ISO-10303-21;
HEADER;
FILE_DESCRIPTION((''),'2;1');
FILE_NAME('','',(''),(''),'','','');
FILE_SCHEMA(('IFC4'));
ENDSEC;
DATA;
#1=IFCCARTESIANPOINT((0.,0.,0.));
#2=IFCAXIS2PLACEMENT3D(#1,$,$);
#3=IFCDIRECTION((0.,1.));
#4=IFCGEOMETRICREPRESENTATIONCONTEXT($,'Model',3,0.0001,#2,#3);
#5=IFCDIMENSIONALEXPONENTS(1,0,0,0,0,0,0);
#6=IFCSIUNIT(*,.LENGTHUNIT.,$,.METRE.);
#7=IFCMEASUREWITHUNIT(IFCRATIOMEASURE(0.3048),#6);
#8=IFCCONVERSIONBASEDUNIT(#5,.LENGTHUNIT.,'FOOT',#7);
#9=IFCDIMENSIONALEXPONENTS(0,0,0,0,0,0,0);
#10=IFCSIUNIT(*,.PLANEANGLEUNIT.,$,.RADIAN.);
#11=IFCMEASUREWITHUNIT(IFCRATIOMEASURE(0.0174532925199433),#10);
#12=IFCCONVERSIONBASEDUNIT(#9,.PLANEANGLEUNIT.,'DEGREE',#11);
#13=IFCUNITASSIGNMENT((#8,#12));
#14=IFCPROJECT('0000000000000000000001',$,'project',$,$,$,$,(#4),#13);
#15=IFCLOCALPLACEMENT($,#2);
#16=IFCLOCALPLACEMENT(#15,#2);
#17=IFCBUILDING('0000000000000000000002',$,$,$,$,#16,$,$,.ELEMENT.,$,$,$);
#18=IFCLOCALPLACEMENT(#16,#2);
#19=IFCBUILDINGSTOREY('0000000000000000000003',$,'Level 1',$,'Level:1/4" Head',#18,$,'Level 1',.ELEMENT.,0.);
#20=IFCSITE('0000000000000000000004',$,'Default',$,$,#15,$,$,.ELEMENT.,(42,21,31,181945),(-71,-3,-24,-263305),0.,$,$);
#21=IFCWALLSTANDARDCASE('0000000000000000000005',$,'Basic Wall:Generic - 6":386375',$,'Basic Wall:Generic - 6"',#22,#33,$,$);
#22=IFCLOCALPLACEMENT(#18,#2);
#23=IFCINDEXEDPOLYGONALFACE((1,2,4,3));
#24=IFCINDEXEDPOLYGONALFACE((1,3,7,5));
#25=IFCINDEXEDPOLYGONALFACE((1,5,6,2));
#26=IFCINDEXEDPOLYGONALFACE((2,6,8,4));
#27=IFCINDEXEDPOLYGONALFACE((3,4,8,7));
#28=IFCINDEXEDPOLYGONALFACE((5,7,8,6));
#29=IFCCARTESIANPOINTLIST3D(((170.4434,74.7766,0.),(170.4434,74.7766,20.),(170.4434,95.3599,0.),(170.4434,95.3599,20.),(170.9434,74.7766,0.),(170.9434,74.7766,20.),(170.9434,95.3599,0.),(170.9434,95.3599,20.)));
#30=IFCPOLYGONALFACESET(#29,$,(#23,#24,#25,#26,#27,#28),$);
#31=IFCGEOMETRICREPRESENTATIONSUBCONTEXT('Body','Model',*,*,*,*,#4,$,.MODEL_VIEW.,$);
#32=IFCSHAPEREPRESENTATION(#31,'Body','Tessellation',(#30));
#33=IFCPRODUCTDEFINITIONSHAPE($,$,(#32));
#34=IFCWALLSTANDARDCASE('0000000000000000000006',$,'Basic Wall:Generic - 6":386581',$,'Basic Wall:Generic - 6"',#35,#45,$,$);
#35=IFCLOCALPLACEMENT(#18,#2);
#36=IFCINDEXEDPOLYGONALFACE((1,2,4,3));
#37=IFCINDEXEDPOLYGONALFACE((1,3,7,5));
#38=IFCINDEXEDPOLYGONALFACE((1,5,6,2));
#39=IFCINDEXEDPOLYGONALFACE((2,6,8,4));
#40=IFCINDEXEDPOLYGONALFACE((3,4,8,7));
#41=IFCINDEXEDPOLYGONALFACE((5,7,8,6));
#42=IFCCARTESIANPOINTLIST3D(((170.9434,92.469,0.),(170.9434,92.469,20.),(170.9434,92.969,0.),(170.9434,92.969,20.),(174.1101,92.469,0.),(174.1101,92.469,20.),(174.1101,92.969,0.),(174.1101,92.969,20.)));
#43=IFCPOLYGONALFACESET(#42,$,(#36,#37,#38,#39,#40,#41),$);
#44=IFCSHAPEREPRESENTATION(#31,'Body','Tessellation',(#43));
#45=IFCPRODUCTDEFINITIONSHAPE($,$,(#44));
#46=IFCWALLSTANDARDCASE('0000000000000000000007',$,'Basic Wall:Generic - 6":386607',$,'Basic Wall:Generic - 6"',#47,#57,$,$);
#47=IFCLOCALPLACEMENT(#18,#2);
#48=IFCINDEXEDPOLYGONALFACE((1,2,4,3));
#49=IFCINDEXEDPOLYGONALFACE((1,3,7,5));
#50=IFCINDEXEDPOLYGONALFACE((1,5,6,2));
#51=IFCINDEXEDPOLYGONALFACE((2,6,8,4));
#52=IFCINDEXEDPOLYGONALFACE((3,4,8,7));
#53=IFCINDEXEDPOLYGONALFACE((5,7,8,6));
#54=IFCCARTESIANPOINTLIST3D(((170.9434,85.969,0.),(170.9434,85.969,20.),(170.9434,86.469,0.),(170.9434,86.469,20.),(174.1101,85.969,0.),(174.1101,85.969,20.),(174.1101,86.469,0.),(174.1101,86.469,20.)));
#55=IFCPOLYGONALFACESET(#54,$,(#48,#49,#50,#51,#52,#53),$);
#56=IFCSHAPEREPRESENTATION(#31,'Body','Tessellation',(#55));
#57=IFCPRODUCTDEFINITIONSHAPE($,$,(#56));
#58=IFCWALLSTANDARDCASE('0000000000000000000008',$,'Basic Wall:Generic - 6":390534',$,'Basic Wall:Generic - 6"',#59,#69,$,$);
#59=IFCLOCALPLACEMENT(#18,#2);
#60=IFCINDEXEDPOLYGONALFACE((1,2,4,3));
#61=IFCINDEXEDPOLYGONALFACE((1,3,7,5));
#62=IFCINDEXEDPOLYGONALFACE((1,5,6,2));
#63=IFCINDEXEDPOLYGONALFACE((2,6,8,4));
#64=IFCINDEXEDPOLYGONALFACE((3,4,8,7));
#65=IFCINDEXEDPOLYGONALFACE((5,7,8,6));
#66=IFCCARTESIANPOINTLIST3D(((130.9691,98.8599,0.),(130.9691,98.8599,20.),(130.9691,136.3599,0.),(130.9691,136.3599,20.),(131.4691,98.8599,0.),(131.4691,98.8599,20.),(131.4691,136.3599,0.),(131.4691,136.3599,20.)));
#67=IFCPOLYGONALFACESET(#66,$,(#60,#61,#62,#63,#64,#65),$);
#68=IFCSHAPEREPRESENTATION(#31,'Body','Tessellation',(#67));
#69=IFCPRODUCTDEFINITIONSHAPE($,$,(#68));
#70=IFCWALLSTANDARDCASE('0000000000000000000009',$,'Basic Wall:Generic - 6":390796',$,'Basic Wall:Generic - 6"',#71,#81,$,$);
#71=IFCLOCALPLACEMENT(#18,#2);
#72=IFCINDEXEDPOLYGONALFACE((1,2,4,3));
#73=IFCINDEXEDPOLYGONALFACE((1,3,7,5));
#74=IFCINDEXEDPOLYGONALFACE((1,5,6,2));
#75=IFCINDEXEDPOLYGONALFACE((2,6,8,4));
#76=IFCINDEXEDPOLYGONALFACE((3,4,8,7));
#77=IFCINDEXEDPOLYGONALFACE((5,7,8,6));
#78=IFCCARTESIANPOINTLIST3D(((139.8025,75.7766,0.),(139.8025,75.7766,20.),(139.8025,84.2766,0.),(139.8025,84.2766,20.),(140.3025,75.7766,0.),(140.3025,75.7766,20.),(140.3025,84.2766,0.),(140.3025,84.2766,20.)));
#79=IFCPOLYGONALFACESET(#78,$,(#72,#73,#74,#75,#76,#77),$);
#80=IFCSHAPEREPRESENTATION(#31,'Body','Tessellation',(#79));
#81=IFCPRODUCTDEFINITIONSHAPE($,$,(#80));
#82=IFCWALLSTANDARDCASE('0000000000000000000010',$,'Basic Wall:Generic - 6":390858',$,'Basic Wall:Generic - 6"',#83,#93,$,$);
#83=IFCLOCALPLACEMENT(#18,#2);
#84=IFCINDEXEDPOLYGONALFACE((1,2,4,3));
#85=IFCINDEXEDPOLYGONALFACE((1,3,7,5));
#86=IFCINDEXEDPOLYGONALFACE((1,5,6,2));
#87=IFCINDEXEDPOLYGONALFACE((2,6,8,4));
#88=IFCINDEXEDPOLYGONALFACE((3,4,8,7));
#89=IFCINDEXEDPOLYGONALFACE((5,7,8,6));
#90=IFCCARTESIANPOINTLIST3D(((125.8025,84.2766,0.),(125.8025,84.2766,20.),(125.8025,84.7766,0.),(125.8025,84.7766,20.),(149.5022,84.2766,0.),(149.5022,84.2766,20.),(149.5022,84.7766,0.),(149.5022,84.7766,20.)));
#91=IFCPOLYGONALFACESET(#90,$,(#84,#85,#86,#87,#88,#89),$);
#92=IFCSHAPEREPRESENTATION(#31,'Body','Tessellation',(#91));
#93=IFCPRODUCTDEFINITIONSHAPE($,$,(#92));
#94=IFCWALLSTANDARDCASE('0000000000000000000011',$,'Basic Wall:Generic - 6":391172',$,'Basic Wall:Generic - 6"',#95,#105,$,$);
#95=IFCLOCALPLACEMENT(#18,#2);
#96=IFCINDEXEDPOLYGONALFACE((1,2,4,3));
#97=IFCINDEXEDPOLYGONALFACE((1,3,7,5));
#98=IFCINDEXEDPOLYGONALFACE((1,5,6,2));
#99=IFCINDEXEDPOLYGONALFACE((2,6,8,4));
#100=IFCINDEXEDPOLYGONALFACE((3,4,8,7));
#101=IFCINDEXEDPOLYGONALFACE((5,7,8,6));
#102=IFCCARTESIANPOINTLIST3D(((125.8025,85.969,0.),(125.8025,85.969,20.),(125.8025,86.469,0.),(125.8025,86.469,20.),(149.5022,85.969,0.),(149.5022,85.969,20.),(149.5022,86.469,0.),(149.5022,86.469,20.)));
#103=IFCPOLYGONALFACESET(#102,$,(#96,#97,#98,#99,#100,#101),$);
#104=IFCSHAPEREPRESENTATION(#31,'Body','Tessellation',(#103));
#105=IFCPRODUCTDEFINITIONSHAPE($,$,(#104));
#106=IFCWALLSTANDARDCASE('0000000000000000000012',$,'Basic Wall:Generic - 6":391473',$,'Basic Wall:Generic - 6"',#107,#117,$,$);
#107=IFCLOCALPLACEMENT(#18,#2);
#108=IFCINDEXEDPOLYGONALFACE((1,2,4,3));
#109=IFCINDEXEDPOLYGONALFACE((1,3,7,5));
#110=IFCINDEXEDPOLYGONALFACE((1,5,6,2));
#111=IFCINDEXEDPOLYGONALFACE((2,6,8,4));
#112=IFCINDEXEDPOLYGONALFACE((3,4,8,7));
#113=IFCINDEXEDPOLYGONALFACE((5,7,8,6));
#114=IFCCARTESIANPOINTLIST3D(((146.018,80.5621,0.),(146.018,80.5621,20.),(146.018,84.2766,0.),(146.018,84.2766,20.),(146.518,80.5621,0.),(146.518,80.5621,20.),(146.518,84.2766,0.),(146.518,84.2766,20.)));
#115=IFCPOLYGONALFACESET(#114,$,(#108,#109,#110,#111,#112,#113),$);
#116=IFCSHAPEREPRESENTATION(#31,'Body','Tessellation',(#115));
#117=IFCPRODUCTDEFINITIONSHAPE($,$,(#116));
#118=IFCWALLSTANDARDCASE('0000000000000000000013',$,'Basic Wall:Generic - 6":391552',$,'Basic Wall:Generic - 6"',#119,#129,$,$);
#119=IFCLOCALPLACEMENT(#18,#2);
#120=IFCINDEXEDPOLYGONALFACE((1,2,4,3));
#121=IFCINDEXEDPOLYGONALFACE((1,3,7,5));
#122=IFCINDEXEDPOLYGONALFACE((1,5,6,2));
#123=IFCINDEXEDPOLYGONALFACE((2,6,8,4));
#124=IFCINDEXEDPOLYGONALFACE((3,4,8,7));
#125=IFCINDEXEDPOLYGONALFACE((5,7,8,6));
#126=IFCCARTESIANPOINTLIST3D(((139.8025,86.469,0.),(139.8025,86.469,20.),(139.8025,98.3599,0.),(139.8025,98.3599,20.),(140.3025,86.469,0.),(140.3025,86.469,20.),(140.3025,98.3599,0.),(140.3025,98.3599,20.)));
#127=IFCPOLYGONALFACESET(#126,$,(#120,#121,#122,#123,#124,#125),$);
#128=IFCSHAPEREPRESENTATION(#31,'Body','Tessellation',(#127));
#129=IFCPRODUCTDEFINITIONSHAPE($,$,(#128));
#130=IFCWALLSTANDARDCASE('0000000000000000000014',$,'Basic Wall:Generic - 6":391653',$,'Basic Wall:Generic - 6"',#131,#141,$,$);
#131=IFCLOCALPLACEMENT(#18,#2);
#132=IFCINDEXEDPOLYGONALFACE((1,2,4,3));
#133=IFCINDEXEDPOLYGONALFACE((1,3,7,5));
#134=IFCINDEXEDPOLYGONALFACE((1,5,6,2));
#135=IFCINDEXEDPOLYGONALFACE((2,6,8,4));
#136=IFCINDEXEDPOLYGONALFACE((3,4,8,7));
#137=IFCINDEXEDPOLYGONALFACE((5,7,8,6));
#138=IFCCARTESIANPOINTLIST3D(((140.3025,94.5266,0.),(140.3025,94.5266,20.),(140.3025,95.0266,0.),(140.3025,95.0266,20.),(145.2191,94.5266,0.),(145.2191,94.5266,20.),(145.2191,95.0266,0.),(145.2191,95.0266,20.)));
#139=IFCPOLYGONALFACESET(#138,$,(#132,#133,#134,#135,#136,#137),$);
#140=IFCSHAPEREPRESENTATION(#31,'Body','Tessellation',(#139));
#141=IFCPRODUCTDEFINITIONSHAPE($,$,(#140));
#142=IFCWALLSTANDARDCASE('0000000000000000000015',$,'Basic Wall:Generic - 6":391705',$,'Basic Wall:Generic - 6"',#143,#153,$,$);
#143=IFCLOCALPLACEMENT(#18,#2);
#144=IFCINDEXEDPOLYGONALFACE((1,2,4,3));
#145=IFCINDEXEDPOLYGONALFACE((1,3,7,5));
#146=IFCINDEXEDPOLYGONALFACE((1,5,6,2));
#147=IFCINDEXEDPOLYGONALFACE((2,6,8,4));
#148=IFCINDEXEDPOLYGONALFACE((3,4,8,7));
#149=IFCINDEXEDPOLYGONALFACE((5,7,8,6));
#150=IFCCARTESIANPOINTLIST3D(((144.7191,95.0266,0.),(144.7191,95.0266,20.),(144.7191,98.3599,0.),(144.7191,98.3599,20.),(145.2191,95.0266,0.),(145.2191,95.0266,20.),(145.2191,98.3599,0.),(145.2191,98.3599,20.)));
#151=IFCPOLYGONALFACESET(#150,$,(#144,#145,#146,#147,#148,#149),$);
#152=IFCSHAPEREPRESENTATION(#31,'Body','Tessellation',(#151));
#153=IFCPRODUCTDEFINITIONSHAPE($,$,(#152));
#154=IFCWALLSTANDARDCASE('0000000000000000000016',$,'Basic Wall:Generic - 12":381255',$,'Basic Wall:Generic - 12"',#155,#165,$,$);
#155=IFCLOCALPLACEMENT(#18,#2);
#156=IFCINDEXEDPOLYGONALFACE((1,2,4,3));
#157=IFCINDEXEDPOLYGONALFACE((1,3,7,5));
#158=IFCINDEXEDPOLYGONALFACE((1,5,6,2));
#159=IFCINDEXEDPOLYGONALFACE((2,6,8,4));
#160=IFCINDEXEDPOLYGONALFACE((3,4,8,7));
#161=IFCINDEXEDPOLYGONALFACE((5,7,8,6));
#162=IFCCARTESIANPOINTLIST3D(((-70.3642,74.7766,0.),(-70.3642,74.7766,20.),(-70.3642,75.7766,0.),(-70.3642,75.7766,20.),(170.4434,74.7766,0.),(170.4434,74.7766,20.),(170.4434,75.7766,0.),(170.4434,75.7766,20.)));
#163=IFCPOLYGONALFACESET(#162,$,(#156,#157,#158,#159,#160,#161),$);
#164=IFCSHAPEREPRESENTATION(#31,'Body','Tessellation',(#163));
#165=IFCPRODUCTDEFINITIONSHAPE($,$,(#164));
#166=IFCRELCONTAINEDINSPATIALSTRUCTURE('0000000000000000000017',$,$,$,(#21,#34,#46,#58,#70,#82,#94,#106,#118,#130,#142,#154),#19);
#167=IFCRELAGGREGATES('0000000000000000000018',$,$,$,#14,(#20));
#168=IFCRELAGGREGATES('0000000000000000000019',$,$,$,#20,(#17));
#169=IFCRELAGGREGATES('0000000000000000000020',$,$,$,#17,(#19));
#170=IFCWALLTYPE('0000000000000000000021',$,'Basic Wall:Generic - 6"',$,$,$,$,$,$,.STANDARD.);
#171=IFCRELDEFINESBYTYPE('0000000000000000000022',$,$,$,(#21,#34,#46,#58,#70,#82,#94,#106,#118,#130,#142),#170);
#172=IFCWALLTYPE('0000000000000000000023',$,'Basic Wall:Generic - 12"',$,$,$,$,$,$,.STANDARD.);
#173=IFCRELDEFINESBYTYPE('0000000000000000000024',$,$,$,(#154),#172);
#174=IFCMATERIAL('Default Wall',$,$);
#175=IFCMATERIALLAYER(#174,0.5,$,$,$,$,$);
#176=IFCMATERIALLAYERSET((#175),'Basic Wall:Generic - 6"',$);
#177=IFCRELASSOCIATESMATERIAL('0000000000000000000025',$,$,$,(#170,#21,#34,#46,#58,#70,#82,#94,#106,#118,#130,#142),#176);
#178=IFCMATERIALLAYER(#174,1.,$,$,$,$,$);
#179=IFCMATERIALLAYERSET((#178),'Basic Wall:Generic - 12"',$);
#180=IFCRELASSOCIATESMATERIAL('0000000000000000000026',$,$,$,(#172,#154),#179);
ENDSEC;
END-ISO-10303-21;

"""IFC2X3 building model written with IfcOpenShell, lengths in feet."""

from ifc_helpers import new_model, entity, si_unit, converted_unit, direction, frame, frame_2d, origin, place, context, subcontext, project, spatial, rectangle, extrude, material, layer, layer_set, layer_usage, type_object, element, save


model = new_model("IFC2X3")

# Units and contexts
model_context = context("Model", 3, precision=0.0001, world=origin(), true_north=direction((0.0, 1.0)))
body_context = subcontext(model_context, "Body", "Model", "MODEL_VIEW")
ifc_project = project(units=[converted_unit("LENGTHUNIT", "FOOT", entity("IfcRatioMeasure", 0.3048), si_unit("LENGTHUNIT", "METRE"), dimensions=[1, 0, 0, 0, 0, 0, 0]), converted_unit("PLANEANGLEUNIT", "DEGREE", entity("IfcRatioMeasure", 0.0174532925199433), si_unit("PLANEANGLEUNIT", "RADIAN"), dimensions=[0, 0, 0, 0, 0, 0, 0])], contexts=[model_context])

# Site, building, storey
site_placement = place(None, origin())
site = spatial("IfcSite", under=ifc_project, at=site_placement, Name="Default", CompositionType="ELEMENT", RefLatitude=(42, 21, 31, 181945), RefLongitude=(-71, -3, -24, -263305), RefElevation=0.0)
building_placement = place(site_placement, origin())
building = spatial("IfcBuilding", under=site, at=building_placement, CompositionType="ELEMENT")
storey_placement = place(building_placement, origin())
storey = spatial("IfcBuildingStorey", under=building, at=storey_placement, Name="Level 1", ObjectType="Level:1/4\" Head", LongName="Level 1", CompositionType="ELEMENT", Elevation=0.0)

# Walls
ifc_material = material(Name="Default Wall")
ifc_layer_1 = layer(ifc_material, 0.5)
ifc_layer_set_1 = layer_set([ifc_layer_1], Name="Basic Wall:Generic - 6\"")
wall_type_1 = type_object("IfcWallType", Name="Basic Wall:Generic - 6\"", PredefinedType="STANDARD", material=ifc_layer_set_1)
ifc_layer_usage_1 = layer_usage(ifc_layer_set_1, "AXIS2", "NEGATIVE", 0.25)
wall_1_placement = place(storey_placement, frame((170.6934, 95.3599, 0.0), z_axis=(0.0, 0.0, 1.0), x_axis=(0.0, -1.0, 0.0)))
element("IfcWallStandardCase", 1, at=wall_1_placement, inside=storey, type_object=wall_type_1, material=ifc_layer_usage_1, Name="Basic Wall:Generic - 6\":386375", ObjectType="Basic Wall:Generic - 6\"", context=body_context, shape_type="SweptSolid", body=[
    extrude(rectangle(XDim=20.5833, YDim=0.5, at=frame_2d((10.2917, 0.0), x_axis=(-1.0, 0.0))), origin(), (0.0, 0.0, 1.0), 20.0),
])
ifc_layer_usage_2 = layer_usage(ifc_layer_set_1, "AXIS2", "NEGATIVE", 0.25)
wall_2_placement = place(storey_placement, frame((170.9434, 92.719, 0.0)))
element("IfcWallStandardCase", 2, at=wall_2_placement, inside=storey, type_object=wall_type_1, material=ifc_layer_usage_2, Name="Basic Wall:Generic - 6\":386581", ObjectType="Basic Wall:Generic - 6\"", context=body_context, shape_type="SweptSolid", body=[
    extrude(rectangle(XDim=3.1667, YDim=0.5, at=frame_2d((1.5833, 0.0), x_axis=(-1.0, 0.0))), origin(), (0.0, 0.0, 1.0), 20.0),
])
ifc_layer_usage_3 = layer_usage(ifc_layer_set_1, "AXIS2", "NEGATIVE", 0.25)
wall_3_placement = place(storey_placement, frame((170.9434, 86.219, 0.0)))
element("IfcWallStandardCase", 3, at=wall_3_placement, inside=storey, type_object=wall_type_1, material=ifc_layer_usage_3, Name="Basic Wall:Generic - 6\":386607", ObjectType="Basic Wall:Generic - 6\"", context=body_context, shape_type="SweptSolid", body=[
    extrude(rectangle(XDim=3.1667, YDim=0.5, at=frame_2d((1.5833, 0.0), x_axis=(-1.0, 0.0))), origin(), (0.0, 0.0, 1.0), 20.0),
])
ifc_layer_usage_4 = layer_usage(ifc_layer_set_1, "AXIS2", "NEGATIVE", 0.25)
wall_4_placement = place(storey_placement, frame((131.2191, 136.3599, 0.0), z_axis=(0.0, 0.0, 1.0), x_axis=(0.0, -1.0, 0.0)))
element("IfcWallStandardCase", 4, at=wall_4_placement, inside=storey, type_object=wall_type_1, material=ifc_layer_usage_4, Name="Basic Wall:Generic - 6\":390534", ObjectType="Basic Wall:Generic - 6\"", context=body_context, shape_type="SweptSolid", body=[
    extrude(rectangle(XDim=37.5, YDim=0.5, at=frame_2d((18.75, 0.0), x_axis=(-1.0, 0.0))), origin(), (0.0, 0.0, 1.0), 20.0),
])
ifc_layer_usage_5 = layer_usage(ifc_layer_set_1, "AXIS2", "NEGATIVE", 0.25)
wall_5_placement = place(storey_placement, frame((140.0525, 75.7766, 0.0), z_axis=(0.0, 0.0, 1.0), x_axis=(0.0, 1.0, 0.0)))
element("IfcWallStandardCase", 5, at=wall_5_placement, inside=storey, type_object=wall_type_1, material=ifc_layer_usage_5, Name="Basic Wall:Generic - 6\":390796", ObjectType="Basic Wall:Generic - 6\"", context=body_context, shape_type="SweptSolid", body=[
    extrude(rectangle(XDim=8.5, YDim=0.5, at=frame_2d((4.25, 0.0), x_axis=(-1.0, 0.0))), origin(), (0.0, 0.0, 1.0), 20.0),
])
ifc_layer_usage_6 = layer_usage(ifc_layer_set_1, "AXIS2", "NEGATIVE", 0.25)
wall_6_placement = place(storey_placement, frame((149.5022, 84.5266, 0.0), z_axis=(0.0, 0.0, 1.0), x_axis=(-1.0, 0.0, 0.0)))
element("IfcWallStandardCase", 6, at=wall_6_placement, inside=storey, type_object=wall_type_1, material=ifc_layer_usage_6, Name="Basic Wall:Generic - 6\":390858", ObjectType="Basic Wall:Generic - 6\"", context=body_context, shape_type="SweptSolid", body=[
    extrude(rectangle(XDim=23.6997, YDim=0.5, at=frame_2d((11.8499, 0.0), x_axis=(-1.0, 0.0))), origin(), (0.0, 0.0, 1.0), 20.0),
])
ifc_layer_usage_7 = layer_usage(ifc_layer_set_1, "AXIS2", "NEGATIVE", 0.25)
wall_7_placement = place(storey_placement, frame((149.5022, 86.219, 0.0), z_axis=(0.0, 0.0, 1.0), x_axis=(-1.0, 0.0, 0.0)))
element("IfcWallStandardCase", 7, at=wall_7_placement, inside=storey, type_object=wall_type_1, material=ifc_layer_usage_7, Name="Basic Wall:Generic - 6\":391172", ObjectType="Basic Wall:Generic - 6\"", context=body_context, shape_type="SweptSolid", body=[
    extrude(rectangle(XDim=23.6997, YDim=0.5, at=frame_2d((11.8499, 0.0), x_axis=(-1.0, 0.0))), origin(), (0.0, 0.0, 1.0), 20.0),
])
ifc_layer_usage_8 = layer_usage(ifc_layer_set_1, "AXIS2", "NEGATIVE", 0.25)
wall_8_placement = place(storey_placement, frame((146.268, 80.5621, 0.0), z_axis=(0.0, 0.0, 1.0), x_axis=(0.0, 1.0, 0.0)))
element("IfcWallStandardCase", 8, at=wall_8_placement, inside=storey, type_object=wall_type_1, material=ifc_layer_usage_8, Name="Basic Wall:Generic - 6\":391473", ObjectType="Basic Wall:Generic - 6\"", context=body_context, shape_type="SweptSolid", body=[
    extrude(rectangle(XDim=3.7145, YDim=0.5, at=frame_2d((1.8573, 0.0), x_axis=(-1.0, 0.0))), origin(), (0.0, 0.0, 1.0), 20.0),
])
ifc_layer_usage_9 = layer_usage(ifc_layer_set_1, "AXIS2", "NEGATIVE", 0.25)
wall_9_placement = place(storey_placement, frame((140.0525, 86.469, 0.0), z_axis=(0.0, 0.0, 1.0), x_axis=(0.0, 1.0, 0.0)))
element("IfcWallStandardCase", 9, at=wall_9_placement, inside=storey, type_object=wall_type_1, material=ifc_layer_usage_9, Name="Basic Wall:Generic - 6\":391552", ObjectType="Basic Wall:Generic - 6\"", context=body_context, shape_type="SweptSolid", body=[
    extrude(rectangle(XDim=11.891, YDim=0.5, at=frame_2d((5.9455, 0.0), x_axis=(-1.0, 0.0))), origin(), (0.0, 0.0, 1.0), 20.0),
])
ifc_layer_usage_10 = layer_usage(ifc_layer_set_1, "AXIS2", "NEGATIVE", 0.25)
wall_10_placement = place(storey_placement, frame((140.3025, 94.7766, 0.0)))
element("IfcWallStandardCase", 10, at=wall_10_placement, inside=storey, type_object=wall_type_1, material=ifc_layer_usage_10, Name="Basic Wall:Generic - 6\":391653", ObjectType="Basic Wall:Generic - 6\"", context=body_context, shape_type="SweptSolid", body=[
    extrude(rectangle(XDim=4.9167, YDim=0.5, at=frame_2d((2.4583, 0.0), x_axis=(-1.0, 0.0))), origin(), (0.0, 0.0, 1.0), 20.0),
])
ifc_layer_usage_11 = layer_usage(ifc_layer_set_1, "AXIS2", "NEGATIVE", 0.25)
wall_11_placement = place(storey_placement, frame((144.9691, 95.0266, 0.0), z_axis=(0.0, 0.0, 1.0), x_axis=(0.0, 1.0, 0.0)))
element("IfcWallStandardCase", 11, at=wall_11_placement, inside=storey, type_object=wall_type_1, material=ifc_layer_usage_11, Name="Basic Wall:Generic - 6\":391705", ObjectType="Basic Wall:Generic - 6\"", context=body_context, shape_type="SweptSolid", body=[
    extrude(rectangle(XDim=3.3333, YDim=0.5, at=frame_2d((1.6667, 0.0), x_axis=(-1.0, 0.0))), origin(), (0.0, 0.0, 1.0), 20.0),
])
ifc_layer_2 = layer(ifc_material, 1.0)
ifc_layer_set_2 = layer_set([ifc_layer_2], Name="Basic Wall:Generic - 12\"")
ifc_layer_usage_12 = layer_usage(ifc_layer_set_2, "AXIS2", "NEGATIVE", 0.5)
wall_type_2 = type_object("IfcWallType", Name="Basic Wall:Generic - 12\"", PredefinedType="STANDARD", material=ifc_layer_set_2)
wall_12_placement = place(storey_placement, frame((170.4434, 75.2766, 0.0), z_axis=(0.0, 0.0, 1.0), x_axis=(-1.0, 0.0, 0.0)))
element("IfcWallStandardCase", 12, at=wall_12_placement, inside=storey, type_object=wall_type_2, material=ifc_layer_usage_12, Name="Basic Wall:Generic - 12\":381255", ObjectType="Basic Wall:Generic - 12\"", context=body_context, shape_type="SweptSolid", body=[
    extrude(rectangle(XDim=240.8076, YDim=1.0, at=frame_2d((120.4038, 0.0), x_axis=(-1.0, 0.0))), origin(), (0.0, 0.0, 1.0), 20.0),
])

save(model, "model.ifc")
